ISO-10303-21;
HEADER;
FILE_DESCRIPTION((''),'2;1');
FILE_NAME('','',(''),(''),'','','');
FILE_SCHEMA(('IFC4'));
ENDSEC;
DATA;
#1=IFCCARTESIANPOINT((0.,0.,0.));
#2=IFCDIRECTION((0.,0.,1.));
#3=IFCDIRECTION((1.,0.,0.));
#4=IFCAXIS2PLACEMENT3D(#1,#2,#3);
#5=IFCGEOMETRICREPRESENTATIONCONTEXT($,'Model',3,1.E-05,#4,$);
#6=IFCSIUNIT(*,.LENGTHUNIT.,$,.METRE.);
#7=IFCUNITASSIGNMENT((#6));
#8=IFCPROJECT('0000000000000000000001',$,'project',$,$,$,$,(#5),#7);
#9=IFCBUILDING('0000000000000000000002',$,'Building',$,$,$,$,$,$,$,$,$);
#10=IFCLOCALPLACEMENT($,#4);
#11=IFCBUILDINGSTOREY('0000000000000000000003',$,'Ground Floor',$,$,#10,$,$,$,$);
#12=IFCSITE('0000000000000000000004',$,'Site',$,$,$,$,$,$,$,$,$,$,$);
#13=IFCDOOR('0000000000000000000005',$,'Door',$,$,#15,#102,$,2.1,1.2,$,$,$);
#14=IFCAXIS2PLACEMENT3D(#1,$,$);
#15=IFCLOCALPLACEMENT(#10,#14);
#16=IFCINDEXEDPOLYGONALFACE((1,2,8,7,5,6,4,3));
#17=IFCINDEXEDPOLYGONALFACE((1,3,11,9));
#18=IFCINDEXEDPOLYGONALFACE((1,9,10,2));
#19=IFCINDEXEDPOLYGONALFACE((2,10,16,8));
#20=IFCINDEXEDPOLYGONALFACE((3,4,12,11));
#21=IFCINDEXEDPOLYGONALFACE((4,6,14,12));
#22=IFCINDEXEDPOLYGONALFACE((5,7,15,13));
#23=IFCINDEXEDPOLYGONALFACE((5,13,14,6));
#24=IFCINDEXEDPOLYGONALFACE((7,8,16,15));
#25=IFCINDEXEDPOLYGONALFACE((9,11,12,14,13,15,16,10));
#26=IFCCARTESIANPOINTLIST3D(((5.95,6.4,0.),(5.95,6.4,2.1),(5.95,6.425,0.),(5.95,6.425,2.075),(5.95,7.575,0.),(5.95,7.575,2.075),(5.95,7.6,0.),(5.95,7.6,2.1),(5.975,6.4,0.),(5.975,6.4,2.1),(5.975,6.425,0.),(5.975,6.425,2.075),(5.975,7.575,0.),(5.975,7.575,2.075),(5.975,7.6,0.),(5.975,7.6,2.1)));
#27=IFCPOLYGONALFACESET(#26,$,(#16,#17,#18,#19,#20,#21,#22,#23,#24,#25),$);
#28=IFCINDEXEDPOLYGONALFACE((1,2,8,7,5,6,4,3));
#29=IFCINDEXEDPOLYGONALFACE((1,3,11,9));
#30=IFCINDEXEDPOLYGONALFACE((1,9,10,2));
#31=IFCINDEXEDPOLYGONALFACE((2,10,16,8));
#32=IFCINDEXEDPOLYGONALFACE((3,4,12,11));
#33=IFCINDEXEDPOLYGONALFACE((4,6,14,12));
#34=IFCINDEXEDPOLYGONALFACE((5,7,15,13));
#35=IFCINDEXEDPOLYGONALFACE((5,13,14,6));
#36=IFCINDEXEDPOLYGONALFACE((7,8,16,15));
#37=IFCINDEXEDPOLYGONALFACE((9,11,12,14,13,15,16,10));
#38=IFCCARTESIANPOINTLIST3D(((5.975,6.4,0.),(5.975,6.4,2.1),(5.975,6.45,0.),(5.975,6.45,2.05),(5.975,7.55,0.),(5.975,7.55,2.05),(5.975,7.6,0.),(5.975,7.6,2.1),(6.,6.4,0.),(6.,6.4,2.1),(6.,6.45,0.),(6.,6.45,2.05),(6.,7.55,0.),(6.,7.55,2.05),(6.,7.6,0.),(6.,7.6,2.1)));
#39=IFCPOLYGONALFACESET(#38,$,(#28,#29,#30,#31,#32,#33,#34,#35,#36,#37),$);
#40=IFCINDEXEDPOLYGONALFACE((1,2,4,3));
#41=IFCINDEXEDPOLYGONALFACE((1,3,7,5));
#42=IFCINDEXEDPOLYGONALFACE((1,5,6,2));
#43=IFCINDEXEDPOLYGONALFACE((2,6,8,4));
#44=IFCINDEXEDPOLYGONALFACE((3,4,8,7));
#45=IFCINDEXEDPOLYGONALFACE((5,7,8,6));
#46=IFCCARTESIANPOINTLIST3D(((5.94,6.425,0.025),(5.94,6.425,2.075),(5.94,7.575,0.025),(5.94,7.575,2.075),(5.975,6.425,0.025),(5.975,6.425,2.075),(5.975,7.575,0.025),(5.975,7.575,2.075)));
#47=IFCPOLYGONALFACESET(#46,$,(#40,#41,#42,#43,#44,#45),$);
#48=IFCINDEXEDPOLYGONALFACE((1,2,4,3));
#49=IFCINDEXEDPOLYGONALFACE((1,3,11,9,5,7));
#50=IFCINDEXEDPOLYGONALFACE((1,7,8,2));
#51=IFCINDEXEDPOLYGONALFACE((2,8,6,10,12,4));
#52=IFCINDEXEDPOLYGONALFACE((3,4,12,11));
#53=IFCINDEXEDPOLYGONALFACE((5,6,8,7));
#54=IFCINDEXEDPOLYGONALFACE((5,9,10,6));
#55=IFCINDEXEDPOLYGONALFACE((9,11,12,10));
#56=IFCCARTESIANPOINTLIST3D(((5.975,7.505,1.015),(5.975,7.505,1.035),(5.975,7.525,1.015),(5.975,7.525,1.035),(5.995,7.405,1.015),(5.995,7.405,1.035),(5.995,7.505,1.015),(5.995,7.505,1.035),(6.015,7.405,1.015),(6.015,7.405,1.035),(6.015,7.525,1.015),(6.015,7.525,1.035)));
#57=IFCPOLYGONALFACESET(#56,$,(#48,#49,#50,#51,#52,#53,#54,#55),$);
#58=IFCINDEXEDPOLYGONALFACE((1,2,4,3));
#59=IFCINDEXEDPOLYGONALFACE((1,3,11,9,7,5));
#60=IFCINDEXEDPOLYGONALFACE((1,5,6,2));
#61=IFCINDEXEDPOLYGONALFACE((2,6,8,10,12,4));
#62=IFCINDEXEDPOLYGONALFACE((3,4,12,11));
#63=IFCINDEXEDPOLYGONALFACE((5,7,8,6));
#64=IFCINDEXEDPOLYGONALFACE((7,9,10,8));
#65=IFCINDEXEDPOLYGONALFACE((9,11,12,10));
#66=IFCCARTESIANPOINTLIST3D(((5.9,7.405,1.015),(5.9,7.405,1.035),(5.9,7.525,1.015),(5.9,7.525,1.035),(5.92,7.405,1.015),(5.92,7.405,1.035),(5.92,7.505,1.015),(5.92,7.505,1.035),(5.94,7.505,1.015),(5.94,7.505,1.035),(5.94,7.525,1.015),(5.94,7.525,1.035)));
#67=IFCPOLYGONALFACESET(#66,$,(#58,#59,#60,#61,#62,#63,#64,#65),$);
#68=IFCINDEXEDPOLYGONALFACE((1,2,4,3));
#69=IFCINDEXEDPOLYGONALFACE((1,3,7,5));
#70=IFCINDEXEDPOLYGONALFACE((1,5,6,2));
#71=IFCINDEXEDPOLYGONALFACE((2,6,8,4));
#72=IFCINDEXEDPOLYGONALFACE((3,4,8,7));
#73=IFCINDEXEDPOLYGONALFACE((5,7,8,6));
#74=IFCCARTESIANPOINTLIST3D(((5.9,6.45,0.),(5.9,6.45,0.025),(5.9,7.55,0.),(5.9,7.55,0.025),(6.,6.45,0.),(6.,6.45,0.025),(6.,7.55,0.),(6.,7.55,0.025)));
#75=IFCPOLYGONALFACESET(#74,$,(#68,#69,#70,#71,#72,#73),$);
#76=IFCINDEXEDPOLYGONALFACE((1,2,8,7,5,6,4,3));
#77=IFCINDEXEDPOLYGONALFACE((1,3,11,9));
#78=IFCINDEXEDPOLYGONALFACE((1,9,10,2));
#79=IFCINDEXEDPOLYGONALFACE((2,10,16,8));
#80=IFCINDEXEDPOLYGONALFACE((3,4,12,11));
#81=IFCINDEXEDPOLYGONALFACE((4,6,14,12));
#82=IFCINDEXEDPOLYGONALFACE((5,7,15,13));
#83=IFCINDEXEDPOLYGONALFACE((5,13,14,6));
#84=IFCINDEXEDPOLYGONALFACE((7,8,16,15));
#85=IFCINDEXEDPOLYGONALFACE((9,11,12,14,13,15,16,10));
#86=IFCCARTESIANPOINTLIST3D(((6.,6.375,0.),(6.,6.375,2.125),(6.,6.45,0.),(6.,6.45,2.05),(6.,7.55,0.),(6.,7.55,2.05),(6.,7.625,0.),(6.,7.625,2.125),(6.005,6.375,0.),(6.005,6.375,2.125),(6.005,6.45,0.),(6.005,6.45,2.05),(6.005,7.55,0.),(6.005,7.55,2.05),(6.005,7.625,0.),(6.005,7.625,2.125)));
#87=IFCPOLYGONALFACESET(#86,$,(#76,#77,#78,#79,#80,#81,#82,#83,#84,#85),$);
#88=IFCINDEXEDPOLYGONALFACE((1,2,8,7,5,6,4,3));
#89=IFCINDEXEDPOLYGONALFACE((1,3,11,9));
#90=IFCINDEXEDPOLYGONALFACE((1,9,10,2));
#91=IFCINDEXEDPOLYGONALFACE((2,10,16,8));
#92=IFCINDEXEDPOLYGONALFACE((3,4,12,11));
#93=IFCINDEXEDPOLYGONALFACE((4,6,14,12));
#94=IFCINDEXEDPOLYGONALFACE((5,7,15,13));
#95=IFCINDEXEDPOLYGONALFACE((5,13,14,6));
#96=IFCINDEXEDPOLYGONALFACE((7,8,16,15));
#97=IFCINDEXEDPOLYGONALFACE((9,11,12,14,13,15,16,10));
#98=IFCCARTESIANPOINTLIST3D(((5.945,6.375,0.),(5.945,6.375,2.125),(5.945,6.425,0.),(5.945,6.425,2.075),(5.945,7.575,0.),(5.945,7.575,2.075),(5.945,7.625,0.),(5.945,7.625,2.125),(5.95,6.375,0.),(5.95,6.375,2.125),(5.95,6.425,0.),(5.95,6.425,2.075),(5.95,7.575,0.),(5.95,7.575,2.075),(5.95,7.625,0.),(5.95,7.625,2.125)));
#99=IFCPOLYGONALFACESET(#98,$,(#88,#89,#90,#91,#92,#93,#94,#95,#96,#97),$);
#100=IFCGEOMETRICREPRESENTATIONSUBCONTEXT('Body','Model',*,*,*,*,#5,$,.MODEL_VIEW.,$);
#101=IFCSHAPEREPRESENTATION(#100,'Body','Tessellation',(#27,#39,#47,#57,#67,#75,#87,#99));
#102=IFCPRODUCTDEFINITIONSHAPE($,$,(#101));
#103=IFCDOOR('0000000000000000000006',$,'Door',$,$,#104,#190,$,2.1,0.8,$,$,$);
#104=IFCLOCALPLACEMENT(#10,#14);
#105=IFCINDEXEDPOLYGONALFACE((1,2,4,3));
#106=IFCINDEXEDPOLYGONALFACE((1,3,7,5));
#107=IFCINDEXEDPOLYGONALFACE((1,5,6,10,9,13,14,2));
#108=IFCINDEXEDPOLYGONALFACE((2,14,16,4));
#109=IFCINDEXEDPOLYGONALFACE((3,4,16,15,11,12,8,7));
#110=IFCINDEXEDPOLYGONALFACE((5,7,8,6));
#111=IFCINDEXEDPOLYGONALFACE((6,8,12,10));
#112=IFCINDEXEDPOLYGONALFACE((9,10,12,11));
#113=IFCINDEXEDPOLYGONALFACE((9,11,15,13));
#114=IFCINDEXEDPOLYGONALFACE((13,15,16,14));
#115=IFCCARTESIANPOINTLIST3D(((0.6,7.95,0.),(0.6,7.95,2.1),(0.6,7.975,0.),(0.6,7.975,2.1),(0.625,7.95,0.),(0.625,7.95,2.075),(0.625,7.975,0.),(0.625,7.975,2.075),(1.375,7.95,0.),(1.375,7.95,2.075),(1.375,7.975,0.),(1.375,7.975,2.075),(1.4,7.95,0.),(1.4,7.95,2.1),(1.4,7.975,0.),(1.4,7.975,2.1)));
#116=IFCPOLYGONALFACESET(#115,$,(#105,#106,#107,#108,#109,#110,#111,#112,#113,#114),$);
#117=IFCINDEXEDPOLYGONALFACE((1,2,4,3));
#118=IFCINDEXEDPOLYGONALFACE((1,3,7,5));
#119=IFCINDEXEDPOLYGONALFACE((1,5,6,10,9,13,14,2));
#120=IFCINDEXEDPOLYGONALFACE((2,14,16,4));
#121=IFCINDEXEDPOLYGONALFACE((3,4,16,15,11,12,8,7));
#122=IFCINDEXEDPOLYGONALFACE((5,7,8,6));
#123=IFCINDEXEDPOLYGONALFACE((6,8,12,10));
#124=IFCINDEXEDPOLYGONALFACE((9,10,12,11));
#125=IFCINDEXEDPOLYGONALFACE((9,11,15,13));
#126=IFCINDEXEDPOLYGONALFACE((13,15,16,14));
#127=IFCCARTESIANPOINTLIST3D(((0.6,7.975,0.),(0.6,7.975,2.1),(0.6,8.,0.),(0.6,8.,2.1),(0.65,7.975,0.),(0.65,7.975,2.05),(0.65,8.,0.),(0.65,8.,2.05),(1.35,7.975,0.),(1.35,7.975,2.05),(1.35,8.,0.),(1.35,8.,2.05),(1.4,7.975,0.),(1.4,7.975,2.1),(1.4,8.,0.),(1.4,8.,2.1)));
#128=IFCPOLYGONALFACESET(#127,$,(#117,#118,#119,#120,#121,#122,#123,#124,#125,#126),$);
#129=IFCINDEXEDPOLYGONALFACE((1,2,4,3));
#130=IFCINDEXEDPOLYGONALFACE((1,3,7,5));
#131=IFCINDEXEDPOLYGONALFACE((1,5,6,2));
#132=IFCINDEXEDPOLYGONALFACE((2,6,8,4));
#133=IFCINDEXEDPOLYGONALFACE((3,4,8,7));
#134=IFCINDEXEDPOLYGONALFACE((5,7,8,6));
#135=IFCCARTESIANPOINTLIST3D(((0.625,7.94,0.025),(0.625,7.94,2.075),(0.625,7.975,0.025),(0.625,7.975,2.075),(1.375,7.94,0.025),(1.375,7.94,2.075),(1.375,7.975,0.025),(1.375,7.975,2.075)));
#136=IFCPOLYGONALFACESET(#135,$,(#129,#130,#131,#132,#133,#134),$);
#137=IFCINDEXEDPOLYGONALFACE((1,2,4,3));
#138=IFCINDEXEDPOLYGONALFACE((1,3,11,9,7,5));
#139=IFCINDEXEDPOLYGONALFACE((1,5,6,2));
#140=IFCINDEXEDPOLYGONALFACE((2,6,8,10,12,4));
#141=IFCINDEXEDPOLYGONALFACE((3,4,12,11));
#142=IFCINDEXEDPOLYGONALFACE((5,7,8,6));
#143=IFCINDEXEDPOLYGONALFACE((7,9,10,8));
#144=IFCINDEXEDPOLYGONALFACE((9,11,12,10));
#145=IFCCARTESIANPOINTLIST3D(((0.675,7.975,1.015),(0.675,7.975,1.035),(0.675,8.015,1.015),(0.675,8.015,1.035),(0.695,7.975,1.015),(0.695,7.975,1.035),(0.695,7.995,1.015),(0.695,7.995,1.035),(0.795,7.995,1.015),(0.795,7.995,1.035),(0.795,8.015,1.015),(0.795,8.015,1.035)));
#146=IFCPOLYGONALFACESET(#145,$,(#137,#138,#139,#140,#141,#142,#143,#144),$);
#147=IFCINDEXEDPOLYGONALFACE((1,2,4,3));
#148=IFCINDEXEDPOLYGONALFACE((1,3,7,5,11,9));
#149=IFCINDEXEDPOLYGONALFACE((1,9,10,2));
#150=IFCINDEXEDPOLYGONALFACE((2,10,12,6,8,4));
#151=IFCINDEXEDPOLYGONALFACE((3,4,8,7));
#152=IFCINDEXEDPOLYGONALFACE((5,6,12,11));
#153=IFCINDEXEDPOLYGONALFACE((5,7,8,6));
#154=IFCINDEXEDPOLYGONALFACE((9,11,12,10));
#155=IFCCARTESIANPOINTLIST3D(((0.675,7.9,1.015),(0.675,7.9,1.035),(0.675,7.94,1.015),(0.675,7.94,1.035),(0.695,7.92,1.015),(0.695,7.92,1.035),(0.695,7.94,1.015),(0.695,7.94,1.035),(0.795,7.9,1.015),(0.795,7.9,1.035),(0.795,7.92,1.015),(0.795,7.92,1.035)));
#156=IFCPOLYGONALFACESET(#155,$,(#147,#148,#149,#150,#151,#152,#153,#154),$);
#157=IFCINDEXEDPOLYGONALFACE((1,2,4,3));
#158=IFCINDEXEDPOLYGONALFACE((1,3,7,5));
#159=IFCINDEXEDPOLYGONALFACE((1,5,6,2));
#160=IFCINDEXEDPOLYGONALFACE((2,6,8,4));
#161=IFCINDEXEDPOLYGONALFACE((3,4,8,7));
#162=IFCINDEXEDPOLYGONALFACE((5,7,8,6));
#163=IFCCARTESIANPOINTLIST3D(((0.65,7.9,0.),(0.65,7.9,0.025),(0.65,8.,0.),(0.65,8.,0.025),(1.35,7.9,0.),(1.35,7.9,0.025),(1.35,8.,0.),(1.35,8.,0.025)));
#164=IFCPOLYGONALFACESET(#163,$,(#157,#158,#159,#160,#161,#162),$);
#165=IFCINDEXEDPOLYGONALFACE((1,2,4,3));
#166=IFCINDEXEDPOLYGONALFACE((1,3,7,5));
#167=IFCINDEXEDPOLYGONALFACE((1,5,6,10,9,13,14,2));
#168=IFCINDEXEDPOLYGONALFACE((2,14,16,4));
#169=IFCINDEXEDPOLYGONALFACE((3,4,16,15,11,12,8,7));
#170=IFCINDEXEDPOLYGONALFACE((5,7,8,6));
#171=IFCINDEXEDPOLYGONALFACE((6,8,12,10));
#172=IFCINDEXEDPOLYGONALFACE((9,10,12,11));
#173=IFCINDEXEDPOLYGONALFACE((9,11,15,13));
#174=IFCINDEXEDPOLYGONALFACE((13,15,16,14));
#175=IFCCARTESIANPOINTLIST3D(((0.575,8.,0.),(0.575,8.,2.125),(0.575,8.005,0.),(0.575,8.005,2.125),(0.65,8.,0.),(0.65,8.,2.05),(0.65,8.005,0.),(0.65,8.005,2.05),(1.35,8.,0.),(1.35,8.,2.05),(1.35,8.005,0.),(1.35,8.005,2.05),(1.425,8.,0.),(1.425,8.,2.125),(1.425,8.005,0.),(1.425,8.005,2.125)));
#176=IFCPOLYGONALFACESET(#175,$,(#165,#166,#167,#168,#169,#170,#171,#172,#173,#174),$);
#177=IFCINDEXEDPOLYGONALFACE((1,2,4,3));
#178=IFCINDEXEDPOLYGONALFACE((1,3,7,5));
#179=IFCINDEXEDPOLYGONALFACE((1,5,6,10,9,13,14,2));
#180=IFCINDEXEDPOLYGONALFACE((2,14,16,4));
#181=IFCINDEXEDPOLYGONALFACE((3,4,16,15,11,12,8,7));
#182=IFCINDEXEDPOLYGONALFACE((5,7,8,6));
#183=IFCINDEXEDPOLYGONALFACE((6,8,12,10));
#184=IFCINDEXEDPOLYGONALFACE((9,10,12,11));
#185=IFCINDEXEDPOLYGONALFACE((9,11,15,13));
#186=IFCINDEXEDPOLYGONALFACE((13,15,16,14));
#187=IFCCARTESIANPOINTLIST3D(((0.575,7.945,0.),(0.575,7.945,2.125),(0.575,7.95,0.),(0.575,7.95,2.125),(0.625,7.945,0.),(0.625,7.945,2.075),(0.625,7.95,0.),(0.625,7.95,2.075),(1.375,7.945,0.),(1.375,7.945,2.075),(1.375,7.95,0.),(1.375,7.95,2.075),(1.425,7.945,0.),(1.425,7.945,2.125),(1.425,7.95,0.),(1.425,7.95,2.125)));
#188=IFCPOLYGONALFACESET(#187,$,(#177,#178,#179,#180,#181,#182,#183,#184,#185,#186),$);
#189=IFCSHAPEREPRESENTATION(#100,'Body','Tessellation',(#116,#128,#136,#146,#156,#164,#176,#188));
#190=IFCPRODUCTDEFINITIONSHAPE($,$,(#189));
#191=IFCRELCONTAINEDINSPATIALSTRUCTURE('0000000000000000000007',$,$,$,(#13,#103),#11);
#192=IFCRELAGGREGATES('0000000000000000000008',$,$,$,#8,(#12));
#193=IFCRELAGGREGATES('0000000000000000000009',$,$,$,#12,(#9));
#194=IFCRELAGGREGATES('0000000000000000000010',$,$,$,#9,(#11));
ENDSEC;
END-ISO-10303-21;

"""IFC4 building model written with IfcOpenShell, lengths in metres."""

from ifc_helpers import new_model, si_unit, frame, origin_with_axes, place, context, subcontext, project, spatial, line, indexed_curve, outline, extrude, element, save


model = new_model("IFC4")

# Units and contexts
model_context = context("Model", 3, precision=1e-05, world=origin_with_axes())
body_context = subcontext(model_context, "Body", "Model", "MODEL_VIEW")
ifc_project = project(units=[si_unit("LENGTHUNIT", "METRE")], contexts=[model_context])

# Site, building, storey
site = spatial("IfcSite", under=ifc_project, Name="Site")
building = spatial("IfcBuilding", under=site, Name="Building")
storey_placement = place(None, origin_with_axes())
storey = spatial("IfcBuildingStorey", under=building, at=storey_placement, Name="Ground Floor")

# Doors
door_1_placement = place(storey_placement, frame((6.0, 6.4, 0.0), z_axis=(0.0, 0.0, 1.0), x_axis=(0.0, 1.0, 0.0)))
element("IfcDoor", 1, at=door_1_placement, inside=storey, Name="Door", OverallHeight=2.1, OverallWidth=1.2, context=body_context, shape_type="SweptSolid", body=[
    extrude(outline(indexed_curve([(0.0, 0.0), (0.0, 2.1), (1.2, 2.1), (1.2, 0.0), (1.175, 0.0), (1.175, 2.075), (0.025, 2.075), (0.025, 0.0)], segments=[line(1, 2, 3, 4, 5, 6, 7, 8, 1)])), frame((0.0, 0.025, 0.0), z_axis=(0.0, -1.0, 0.0), x_axis=(1.0, 0.0, 0.0)), (0.0, 0.0, -1.0), 0.025),
    extrude(outline(indexed_curve([(0.0, 0.0), (0.0, 2.1), (1.2, 2.1), (1.2, 0.0), (1.15, 0.0), (1.15, 2.05), (0.05, 2.05), (0.05, 0.0)], segments=[line(1, 2, 3, 4, 5, 6, 7, 8, 1)])), frame((0.0, 0.0, 0.0), z_axis=(0.0, -1.0, 0.0), x_axis=(1.0, 0.0, 0.0)), (0.0, 0.0, -1.0), 0.025),
    extrude(outline(indexed_curve([(0.0, 0.0), (1.15, 0.0), (1.15, 0.035), (0.0, 0.035)], segments=[line(1, 2, 3, 4, 1)])), frame((0.025, 0.025, 0.025), z_axis=(0.0, 0.0, 1.0), x_axis=(1.0, 0.0, 0.0)), (0.0, 0.0, 1.0), 2.05),
    extrude(outline(indexed_curve([(0.0, 0.0), (0.0, -0.04), (-0.12, -0.04), (-0.12, -0.02), (-0.02, -0.02), (-0.02, 0.0)], segments=[line(1, 2, 3, 4, 5, 6, 1)])), frame((1.125, 0.025, 1.015), z_axis=(0.0, 0.0, 1.0), x_axis=(1.0, 0.0, 0.0)), (0.0, 0.0, 1.0), 0.02),
    extrude(outline(indexed_curve([(0.0, 0.0), (0.0, 0.04), (-0.12, 0.04), (-0.12, 0.02), (-0.02, 0.02), (-0.02, 0.0)], segments=[line(1, 2, 3, 4, 5, 6, 1)])), frame((1.125, 0.06, 1.015), z_axis=(0.0, 0.0, 1.0), x_axis=(1.0, 0.0, 0.0)), (0.0, 0.0, 1.0), 0.02),
    extrude(outline(indexed_curve([(0.0, 0.0), (1.1, 0.0), (1.1, 0.1), (0.0, 0.1)], segments=[line(1, 2, 3, 4, 1)])), frame((0.05, 0.0, 0.0), z_axis=(0.0, 0.0, 1.0), x_axis=(1.0, 0.0, 0.0)), (0.0, 0.0, 1.0), 0.025),
    extrude(outline(indexed_curve([(0.0, 0.0), (0.0, 2.125), (1.25, 2.125), (1.25, 0.0), (1.175, 0.0), (1.175, 2.05), (0.075, 2.05), (0.075, 0.0)], segments=[line(1, 2, 3, 4, 5, 6, 7, 8, 1)])), frame((-0.025, -0.005, 0.0), z_axis=(0.0, -1.0, 0.0), x_axis=(1.0, 0.0, 0.0)), (0.0, 0.0, -1.0), 0.005),
    extrude(outline(indexed_curve([(0.0, 0.0), (0.0, 2.125), (1.25, 2.125), (1.25, 0.0), (1.2, 0.0), (1.2, 2.075), (0.05, 2.075), (0.05, 0.0)], segments=[line(1, 2, 3, 4, 5, 6, 7, 8, 1)])), frame((-0.025, 0.05, 0.0), z_axis=(0.0, -1.0, 0.0), x_axis=(1.0, 0.0, 0.0)), (0.0, 0.0, -1.0), 0.005),
])
door_2_placement = place(storey_placement, frame((1.4, 8.0, 0.0), z_axis=(0.0, 0.0, 1.0), x_axis=(-1.0, 0.0, 0.0)))
element("IfcDoor", 2, at=door_2_placement, inside=storey, Name="Door", OverallHeight=2.1, OverallWidth=0.8, context=body_context, shape_type="SweptSolid", body=[
    extrude(outline(indexed_curve([(0.0, 0.0), (0.0, 2.1), (0.8, 2.1), (0.8, 0.0), (0.775, 0.0), (0.775, 2.075), (0.025, 2.075), (0.025, 0.0)], segments=[line(1, 2, 3, 4, 5, 6, 7, 8, 1)])), frame((0.0, 0.025, 0.0), z_axis=(0.0, -1.0, 0.0), x_axis=(1.0, 0.0, 0.0)), (0.0, 0.0, -1.0), 0.025),
    extrude(outline(indexed_curve([(0.0, 0.0), (0.0, 2.1), (0.8, 2.1), (0.8, 0.0), (0.75, 0.0), (0.75, 2.05), (0.05, 2.05), (0.05, 0.0)], segments=[line(1, 2, 3, 4, 5, 6, 7, 8, 1)])), frame((0.0, 0.0, 0.0), z_axis=(0.0, -1.0, 0.0), x_axis=(1.0, 0.0, 0.0)), (0.0, 0.0, -1.0), 0.025),
    extrude(outline(indexed_curve([(0.0, 0.0), (0.75, 0.0), (0.75, 0.035), (0.0, 0.035)], segments=[line(1, 2, 3, 4, 1)])), frame((0.025, 0.025, 0.025), z_axis=(0.0, 0.0, 1.0), x_axis=(1.0, 0.0, 0.0)), (0.0, 0.0, 1.0), 2.05),
    extrude(outline(indexed_curve([(0.0, 0.0), (0.0, -0.04), (-0.12, -0.04), (-0.12, -0.02), (-0.02, -0.02), (-0.02, 0.0)], segments=[line(1, 2, 3, 4, 5, 6, 1)])), frame((0.725, 0.025, 1.015), z_axis=(0.0, 0.0, 1.0), x_axis=(1.0, 0.0, 0.0)), (0.0, 0.0, 1.0), 0.02),
    extrude(outline(indexed_curve([(0.0, 0.0), (0.0, 0.04), (-0.12, 0.04), (-0.12, 0.02), (-0.02, 0.02), (-0.02, 0.0)], segments=[line(1, 2, 3, 4, 5, 6, 1)])), frame((0.725, 0.06, 1.015), z_axis=(0.0, 0.0, 1.0), x_axis=(1.0, 0.0, 0.0)), (0.0, 0.0, 1.0), 0.02),
    extrude(outline(indexed_curve([(0.0, 0.0), (0.7, 0.0), (0.7, 0.1), (0.0, 0.1)], segments=[line(1, 2, 3, 4, 1)])), frame((0.05, 0.0, 0.0), z_axis=(0.0, 0.0, 1.0), x_axis=(1.0, 0.0, 0.0)), (0.0, 0.0, 1.0), 0.025),
    extrude(outline(indexed_curve([(0.0, 0.0), (0.0, 2.125), (0.85, 2.125), (0.85, 0.0), (0.775, 0.0), (0.775, 2.05), (0.075, 2.05), (0.075, 0.0)], segments=[line(1, 2, 3, 4, 5, 6, 7, 8, 1)])), frame((-0.025, -0.005, 0.0), z_axis=(0.0, -1.0, 0.0), x_axis=(1.0, 0.0, 0.0)), (0.0, 0.0, -1.0), 0.005),
    extrude(outline(indexed_curve([(0.0, 0.0), (0.0, 2.125), (0.85, 2.125), (0.85, 0.0), (0.8, 0.0), (0.8, 2.075), (0.05, 2.075), (0.05, 0.0)], segments=[line(1, 2, 3, 4, 5, 6, 7, 8, 1)])), frame((-0.025, 0.05, 0.0), z_axis=(0.0, -1.0, 0.0), x_axis=(1.0, 0.0, 0.0)), (0.0, 0.0, -1.0), 0.005),
])

save(model, "model.ifc")
